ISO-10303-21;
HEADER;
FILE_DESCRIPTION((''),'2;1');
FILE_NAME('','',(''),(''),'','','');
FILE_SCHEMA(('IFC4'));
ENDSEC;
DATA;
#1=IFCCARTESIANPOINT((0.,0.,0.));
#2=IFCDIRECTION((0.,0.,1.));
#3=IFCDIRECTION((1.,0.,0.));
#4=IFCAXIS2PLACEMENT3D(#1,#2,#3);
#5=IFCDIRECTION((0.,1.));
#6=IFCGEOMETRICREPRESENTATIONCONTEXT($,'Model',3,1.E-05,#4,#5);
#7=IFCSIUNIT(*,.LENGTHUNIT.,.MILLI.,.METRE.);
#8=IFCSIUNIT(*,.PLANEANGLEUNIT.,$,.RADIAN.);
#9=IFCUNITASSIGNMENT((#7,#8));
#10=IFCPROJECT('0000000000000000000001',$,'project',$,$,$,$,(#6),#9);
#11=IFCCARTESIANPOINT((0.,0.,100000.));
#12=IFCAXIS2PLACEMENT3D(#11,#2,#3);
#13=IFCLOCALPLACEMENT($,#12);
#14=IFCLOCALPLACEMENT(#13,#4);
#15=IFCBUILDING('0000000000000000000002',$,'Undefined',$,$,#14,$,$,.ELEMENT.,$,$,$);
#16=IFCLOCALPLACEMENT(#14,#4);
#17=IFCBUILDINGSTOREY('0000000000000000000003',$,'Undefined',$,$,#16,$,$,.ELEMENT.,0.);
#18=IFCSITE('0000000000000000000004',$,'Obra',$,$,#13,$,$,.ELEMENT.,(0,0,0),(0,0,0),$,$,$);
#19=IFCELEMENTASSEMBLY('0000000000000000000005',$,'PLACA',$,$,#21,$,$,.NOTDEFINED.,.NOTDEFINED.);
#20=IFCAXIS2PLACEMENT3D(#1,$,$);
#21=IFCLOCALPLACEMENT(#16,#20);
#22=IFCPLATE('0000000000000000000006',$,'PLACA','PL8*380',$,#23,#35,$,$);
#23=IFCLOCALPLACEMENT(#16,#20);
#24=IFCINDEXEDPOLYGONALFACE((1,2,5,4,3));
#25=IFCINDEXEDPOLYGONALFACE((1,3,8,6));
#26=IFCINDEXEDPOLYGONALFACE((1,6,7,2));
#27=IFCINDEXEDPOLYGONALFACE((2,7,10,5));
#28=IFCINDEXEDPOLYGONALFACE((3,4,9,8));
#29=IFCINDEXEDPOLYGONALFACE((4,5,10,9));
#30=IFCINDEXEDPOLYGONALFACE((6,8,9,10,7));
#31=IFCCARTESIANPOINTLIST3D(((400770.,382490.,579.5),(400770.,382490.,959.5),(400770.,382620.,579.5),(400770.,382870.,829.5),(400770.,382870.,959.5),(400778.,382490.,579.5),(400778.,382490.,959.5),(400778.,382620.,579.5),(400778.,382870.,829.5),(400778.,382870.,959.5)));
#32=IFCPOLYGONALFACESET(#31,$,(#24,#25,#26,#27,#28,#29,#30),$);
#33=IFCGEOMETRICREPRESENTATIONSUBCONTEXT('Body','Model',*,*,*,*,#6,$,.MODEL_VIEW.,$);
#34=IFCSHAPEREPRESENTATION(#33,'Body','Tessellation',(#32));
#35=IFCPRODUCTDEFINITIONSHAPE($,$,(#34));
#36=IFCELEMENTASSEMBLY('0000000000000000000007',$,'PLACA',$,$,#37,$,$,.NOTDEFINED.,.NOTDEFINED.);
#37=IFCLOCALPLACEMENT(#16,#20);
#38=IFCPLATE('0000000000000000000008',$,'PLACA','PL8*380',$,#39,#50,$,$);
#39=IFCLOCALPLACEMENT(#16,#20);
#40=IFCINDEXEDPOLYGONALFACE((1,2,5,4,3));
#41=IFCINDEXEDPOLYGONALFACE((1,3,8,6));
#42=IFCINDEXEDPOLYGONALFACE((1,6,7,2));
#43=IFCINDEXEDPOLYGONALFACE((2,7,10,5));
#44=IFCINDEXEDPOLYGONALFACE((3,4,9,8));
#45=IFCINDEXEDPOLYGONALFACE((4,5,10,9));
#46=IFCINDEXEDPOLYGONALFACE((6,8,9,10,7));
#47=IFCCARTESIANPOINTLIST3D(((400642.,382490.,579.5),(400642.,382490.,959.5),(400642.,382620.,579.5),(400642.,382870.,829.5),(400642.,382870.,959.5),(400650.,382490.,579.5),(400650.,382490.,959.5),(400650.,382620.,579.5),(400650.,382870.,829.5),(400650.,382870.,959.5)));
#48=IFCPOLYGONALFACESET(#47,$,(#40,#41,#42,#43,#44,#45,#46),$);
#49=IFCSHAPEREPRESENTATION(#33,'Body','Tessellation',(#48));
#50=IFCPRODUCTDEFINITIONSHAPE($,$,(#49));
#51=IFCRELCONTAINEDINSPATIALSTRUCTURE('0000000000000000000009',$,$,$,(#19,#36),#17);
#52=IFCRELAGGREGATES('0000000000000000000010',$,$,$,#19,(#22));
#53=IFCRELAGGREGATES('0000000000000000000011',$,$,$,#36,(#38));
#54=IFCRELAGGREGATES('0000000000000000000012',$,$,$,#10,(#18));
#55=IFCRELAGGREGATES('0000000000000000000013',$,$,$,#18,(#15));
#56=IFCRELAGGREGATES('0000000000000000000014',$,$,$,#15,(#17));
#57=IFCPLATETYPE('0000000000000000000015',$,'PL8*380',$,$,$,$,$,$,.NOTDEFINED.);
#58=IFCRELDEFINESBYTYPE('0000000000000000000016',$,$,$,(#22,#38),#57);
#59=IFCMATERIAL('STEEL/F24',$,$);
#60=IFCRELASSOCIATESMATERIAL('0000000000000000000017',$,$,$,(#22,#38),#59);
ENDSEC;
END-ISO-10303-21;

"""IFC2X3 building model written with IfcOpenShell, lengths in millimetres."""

from ifc_helpers import new_model, si_unit, direction, frame, origin_with_axes, place, context, subcontext, project, spatial, polyline, outline, extrude, material, type_object, element, aggregate, save


model = new_model("IFC2X3")

# Units and contexts
model_context = context("Model", 3, precision=1e-05, world=origin_with_axes(), true_north=direction((0.0, 1.0)))
body_context = subcontext(model_context, "Body", "Model", "MODEL_VIEW")
ifc_project = project(units=[si_unit("LENGTHUNIT", "METRE", prefix="MILLI"), si_unit("PLANEANGLEUNIT", "RADIAN")], contexts=[model_context])

# Site, building, storey
site_placement = place(None, frame((0.0, 0.0, 100000.0), z_axis=(0.0, 0.0, 1.0), x_axis=(1.0, 0.0, 0.0)))
site = spatial("IfcSite", under=ifc_project, at=site_placement, Name="Obra", CompositionType="ELEMENT", RefLatitude=(0, 0, 0), RefLongitude=(0, 0, 0))
building_placement = place(site_placement, origin_with_axes())
building = spatial("IfcBuilding", under=site, at=building_placement, Name="Undefined", CompositionType="ELEMENT")
storey_placement = place(building_placement, origin_with_axes())
storey = spatial("IfcBuildingStorey", under=building, at=storey_placement, Name="Undefined", CompositionType="ELEMENT", Elevation=0.0)

# Shared definitions
ifc_material_1 = material(Name="STEEL/F24")

# Element assemblies, plates
plate_type_1 = type_object("IfcPlateType", Name="PL8*380", PredefinedType="NOTDEFINED")
assembly_1_placement = place(storey_placement, origin_with_axes())
assembly_1 = element("IfcElementAssembly", 1, at=assembly_1_placement, inside=storey, Name="PLACA", AssemblyPlace="NOTDEFINED", PredefinedType="NOTDEFINED")
plate_1_placement = place(assembly_1_placement, frame((400774.0, 382870.0, 959.5), z_axis=(1.0, 0.0, 0.0), x_axis=(0.0, -1.0, 0.0)))
plate_1 = element("IfcPlate", 2, at=plate_1_placement, type_object=plate_type_1, material=ifc_material_1, Name="PLACA", Description="PL8*380", context=body_context, shape_type="SweptSolid", body=[
    extrude(outline(polyline([(0.0, 0.0), (380.0, 0.0), (380.0, 380.0), (250.0, 380.0), (0.0, 130.0), (0.0, 0.0)])), frame((0.0, 0.0, -4.0), z_axis=(0.0, 0.0, 1.0), x_axis=(1.0, 0.0, 0.0)), (0.0, 0.0, 1.0), 8.0),
])
aggregate(assembly_1, [plate_1])
assembly_2_placement = place(storey_placement, origin_with_axes())
assembly_2 = element("IfcElementAssembly", 3, at=assembly_2_placement, inside=storey, Name="PLACA", AssemblyPlace="NOTDEFINED", PredefinedType="NOTDEFINED")
plate_2_placement = place(assembly_2_placement, frame((400646.0, 382870.0, 959.5), z_axis=(1.0, 0.0, 0.0), x_axis=(0.0, -1.0, 0.0)))
plate_2 = element("IfcPlate", 4, at=plate_2_placement, type_object=plate_type_1, material=ifc_material_1, Name="PLACA", Description="PL8*380", context=body_context, shape_type="SweptSolid", body=[
    extrude(outline(polyline([(0.0, 0.0), (380.0, 0.0), (380.0, 380.0), (250.0, 380.0), (0.0, 130.0), (0.0, 0.0)])), frame((0.0, 0.0, -4.0), z_axis=(0.0, 0.0, 1.0), x_axis=(1.0, 0.0, 0.0)), (0.0, 0.0, 1.0), 8.0),
])
aggregate(assembly_2, [plate_2])

save(model, "model.ifc")
